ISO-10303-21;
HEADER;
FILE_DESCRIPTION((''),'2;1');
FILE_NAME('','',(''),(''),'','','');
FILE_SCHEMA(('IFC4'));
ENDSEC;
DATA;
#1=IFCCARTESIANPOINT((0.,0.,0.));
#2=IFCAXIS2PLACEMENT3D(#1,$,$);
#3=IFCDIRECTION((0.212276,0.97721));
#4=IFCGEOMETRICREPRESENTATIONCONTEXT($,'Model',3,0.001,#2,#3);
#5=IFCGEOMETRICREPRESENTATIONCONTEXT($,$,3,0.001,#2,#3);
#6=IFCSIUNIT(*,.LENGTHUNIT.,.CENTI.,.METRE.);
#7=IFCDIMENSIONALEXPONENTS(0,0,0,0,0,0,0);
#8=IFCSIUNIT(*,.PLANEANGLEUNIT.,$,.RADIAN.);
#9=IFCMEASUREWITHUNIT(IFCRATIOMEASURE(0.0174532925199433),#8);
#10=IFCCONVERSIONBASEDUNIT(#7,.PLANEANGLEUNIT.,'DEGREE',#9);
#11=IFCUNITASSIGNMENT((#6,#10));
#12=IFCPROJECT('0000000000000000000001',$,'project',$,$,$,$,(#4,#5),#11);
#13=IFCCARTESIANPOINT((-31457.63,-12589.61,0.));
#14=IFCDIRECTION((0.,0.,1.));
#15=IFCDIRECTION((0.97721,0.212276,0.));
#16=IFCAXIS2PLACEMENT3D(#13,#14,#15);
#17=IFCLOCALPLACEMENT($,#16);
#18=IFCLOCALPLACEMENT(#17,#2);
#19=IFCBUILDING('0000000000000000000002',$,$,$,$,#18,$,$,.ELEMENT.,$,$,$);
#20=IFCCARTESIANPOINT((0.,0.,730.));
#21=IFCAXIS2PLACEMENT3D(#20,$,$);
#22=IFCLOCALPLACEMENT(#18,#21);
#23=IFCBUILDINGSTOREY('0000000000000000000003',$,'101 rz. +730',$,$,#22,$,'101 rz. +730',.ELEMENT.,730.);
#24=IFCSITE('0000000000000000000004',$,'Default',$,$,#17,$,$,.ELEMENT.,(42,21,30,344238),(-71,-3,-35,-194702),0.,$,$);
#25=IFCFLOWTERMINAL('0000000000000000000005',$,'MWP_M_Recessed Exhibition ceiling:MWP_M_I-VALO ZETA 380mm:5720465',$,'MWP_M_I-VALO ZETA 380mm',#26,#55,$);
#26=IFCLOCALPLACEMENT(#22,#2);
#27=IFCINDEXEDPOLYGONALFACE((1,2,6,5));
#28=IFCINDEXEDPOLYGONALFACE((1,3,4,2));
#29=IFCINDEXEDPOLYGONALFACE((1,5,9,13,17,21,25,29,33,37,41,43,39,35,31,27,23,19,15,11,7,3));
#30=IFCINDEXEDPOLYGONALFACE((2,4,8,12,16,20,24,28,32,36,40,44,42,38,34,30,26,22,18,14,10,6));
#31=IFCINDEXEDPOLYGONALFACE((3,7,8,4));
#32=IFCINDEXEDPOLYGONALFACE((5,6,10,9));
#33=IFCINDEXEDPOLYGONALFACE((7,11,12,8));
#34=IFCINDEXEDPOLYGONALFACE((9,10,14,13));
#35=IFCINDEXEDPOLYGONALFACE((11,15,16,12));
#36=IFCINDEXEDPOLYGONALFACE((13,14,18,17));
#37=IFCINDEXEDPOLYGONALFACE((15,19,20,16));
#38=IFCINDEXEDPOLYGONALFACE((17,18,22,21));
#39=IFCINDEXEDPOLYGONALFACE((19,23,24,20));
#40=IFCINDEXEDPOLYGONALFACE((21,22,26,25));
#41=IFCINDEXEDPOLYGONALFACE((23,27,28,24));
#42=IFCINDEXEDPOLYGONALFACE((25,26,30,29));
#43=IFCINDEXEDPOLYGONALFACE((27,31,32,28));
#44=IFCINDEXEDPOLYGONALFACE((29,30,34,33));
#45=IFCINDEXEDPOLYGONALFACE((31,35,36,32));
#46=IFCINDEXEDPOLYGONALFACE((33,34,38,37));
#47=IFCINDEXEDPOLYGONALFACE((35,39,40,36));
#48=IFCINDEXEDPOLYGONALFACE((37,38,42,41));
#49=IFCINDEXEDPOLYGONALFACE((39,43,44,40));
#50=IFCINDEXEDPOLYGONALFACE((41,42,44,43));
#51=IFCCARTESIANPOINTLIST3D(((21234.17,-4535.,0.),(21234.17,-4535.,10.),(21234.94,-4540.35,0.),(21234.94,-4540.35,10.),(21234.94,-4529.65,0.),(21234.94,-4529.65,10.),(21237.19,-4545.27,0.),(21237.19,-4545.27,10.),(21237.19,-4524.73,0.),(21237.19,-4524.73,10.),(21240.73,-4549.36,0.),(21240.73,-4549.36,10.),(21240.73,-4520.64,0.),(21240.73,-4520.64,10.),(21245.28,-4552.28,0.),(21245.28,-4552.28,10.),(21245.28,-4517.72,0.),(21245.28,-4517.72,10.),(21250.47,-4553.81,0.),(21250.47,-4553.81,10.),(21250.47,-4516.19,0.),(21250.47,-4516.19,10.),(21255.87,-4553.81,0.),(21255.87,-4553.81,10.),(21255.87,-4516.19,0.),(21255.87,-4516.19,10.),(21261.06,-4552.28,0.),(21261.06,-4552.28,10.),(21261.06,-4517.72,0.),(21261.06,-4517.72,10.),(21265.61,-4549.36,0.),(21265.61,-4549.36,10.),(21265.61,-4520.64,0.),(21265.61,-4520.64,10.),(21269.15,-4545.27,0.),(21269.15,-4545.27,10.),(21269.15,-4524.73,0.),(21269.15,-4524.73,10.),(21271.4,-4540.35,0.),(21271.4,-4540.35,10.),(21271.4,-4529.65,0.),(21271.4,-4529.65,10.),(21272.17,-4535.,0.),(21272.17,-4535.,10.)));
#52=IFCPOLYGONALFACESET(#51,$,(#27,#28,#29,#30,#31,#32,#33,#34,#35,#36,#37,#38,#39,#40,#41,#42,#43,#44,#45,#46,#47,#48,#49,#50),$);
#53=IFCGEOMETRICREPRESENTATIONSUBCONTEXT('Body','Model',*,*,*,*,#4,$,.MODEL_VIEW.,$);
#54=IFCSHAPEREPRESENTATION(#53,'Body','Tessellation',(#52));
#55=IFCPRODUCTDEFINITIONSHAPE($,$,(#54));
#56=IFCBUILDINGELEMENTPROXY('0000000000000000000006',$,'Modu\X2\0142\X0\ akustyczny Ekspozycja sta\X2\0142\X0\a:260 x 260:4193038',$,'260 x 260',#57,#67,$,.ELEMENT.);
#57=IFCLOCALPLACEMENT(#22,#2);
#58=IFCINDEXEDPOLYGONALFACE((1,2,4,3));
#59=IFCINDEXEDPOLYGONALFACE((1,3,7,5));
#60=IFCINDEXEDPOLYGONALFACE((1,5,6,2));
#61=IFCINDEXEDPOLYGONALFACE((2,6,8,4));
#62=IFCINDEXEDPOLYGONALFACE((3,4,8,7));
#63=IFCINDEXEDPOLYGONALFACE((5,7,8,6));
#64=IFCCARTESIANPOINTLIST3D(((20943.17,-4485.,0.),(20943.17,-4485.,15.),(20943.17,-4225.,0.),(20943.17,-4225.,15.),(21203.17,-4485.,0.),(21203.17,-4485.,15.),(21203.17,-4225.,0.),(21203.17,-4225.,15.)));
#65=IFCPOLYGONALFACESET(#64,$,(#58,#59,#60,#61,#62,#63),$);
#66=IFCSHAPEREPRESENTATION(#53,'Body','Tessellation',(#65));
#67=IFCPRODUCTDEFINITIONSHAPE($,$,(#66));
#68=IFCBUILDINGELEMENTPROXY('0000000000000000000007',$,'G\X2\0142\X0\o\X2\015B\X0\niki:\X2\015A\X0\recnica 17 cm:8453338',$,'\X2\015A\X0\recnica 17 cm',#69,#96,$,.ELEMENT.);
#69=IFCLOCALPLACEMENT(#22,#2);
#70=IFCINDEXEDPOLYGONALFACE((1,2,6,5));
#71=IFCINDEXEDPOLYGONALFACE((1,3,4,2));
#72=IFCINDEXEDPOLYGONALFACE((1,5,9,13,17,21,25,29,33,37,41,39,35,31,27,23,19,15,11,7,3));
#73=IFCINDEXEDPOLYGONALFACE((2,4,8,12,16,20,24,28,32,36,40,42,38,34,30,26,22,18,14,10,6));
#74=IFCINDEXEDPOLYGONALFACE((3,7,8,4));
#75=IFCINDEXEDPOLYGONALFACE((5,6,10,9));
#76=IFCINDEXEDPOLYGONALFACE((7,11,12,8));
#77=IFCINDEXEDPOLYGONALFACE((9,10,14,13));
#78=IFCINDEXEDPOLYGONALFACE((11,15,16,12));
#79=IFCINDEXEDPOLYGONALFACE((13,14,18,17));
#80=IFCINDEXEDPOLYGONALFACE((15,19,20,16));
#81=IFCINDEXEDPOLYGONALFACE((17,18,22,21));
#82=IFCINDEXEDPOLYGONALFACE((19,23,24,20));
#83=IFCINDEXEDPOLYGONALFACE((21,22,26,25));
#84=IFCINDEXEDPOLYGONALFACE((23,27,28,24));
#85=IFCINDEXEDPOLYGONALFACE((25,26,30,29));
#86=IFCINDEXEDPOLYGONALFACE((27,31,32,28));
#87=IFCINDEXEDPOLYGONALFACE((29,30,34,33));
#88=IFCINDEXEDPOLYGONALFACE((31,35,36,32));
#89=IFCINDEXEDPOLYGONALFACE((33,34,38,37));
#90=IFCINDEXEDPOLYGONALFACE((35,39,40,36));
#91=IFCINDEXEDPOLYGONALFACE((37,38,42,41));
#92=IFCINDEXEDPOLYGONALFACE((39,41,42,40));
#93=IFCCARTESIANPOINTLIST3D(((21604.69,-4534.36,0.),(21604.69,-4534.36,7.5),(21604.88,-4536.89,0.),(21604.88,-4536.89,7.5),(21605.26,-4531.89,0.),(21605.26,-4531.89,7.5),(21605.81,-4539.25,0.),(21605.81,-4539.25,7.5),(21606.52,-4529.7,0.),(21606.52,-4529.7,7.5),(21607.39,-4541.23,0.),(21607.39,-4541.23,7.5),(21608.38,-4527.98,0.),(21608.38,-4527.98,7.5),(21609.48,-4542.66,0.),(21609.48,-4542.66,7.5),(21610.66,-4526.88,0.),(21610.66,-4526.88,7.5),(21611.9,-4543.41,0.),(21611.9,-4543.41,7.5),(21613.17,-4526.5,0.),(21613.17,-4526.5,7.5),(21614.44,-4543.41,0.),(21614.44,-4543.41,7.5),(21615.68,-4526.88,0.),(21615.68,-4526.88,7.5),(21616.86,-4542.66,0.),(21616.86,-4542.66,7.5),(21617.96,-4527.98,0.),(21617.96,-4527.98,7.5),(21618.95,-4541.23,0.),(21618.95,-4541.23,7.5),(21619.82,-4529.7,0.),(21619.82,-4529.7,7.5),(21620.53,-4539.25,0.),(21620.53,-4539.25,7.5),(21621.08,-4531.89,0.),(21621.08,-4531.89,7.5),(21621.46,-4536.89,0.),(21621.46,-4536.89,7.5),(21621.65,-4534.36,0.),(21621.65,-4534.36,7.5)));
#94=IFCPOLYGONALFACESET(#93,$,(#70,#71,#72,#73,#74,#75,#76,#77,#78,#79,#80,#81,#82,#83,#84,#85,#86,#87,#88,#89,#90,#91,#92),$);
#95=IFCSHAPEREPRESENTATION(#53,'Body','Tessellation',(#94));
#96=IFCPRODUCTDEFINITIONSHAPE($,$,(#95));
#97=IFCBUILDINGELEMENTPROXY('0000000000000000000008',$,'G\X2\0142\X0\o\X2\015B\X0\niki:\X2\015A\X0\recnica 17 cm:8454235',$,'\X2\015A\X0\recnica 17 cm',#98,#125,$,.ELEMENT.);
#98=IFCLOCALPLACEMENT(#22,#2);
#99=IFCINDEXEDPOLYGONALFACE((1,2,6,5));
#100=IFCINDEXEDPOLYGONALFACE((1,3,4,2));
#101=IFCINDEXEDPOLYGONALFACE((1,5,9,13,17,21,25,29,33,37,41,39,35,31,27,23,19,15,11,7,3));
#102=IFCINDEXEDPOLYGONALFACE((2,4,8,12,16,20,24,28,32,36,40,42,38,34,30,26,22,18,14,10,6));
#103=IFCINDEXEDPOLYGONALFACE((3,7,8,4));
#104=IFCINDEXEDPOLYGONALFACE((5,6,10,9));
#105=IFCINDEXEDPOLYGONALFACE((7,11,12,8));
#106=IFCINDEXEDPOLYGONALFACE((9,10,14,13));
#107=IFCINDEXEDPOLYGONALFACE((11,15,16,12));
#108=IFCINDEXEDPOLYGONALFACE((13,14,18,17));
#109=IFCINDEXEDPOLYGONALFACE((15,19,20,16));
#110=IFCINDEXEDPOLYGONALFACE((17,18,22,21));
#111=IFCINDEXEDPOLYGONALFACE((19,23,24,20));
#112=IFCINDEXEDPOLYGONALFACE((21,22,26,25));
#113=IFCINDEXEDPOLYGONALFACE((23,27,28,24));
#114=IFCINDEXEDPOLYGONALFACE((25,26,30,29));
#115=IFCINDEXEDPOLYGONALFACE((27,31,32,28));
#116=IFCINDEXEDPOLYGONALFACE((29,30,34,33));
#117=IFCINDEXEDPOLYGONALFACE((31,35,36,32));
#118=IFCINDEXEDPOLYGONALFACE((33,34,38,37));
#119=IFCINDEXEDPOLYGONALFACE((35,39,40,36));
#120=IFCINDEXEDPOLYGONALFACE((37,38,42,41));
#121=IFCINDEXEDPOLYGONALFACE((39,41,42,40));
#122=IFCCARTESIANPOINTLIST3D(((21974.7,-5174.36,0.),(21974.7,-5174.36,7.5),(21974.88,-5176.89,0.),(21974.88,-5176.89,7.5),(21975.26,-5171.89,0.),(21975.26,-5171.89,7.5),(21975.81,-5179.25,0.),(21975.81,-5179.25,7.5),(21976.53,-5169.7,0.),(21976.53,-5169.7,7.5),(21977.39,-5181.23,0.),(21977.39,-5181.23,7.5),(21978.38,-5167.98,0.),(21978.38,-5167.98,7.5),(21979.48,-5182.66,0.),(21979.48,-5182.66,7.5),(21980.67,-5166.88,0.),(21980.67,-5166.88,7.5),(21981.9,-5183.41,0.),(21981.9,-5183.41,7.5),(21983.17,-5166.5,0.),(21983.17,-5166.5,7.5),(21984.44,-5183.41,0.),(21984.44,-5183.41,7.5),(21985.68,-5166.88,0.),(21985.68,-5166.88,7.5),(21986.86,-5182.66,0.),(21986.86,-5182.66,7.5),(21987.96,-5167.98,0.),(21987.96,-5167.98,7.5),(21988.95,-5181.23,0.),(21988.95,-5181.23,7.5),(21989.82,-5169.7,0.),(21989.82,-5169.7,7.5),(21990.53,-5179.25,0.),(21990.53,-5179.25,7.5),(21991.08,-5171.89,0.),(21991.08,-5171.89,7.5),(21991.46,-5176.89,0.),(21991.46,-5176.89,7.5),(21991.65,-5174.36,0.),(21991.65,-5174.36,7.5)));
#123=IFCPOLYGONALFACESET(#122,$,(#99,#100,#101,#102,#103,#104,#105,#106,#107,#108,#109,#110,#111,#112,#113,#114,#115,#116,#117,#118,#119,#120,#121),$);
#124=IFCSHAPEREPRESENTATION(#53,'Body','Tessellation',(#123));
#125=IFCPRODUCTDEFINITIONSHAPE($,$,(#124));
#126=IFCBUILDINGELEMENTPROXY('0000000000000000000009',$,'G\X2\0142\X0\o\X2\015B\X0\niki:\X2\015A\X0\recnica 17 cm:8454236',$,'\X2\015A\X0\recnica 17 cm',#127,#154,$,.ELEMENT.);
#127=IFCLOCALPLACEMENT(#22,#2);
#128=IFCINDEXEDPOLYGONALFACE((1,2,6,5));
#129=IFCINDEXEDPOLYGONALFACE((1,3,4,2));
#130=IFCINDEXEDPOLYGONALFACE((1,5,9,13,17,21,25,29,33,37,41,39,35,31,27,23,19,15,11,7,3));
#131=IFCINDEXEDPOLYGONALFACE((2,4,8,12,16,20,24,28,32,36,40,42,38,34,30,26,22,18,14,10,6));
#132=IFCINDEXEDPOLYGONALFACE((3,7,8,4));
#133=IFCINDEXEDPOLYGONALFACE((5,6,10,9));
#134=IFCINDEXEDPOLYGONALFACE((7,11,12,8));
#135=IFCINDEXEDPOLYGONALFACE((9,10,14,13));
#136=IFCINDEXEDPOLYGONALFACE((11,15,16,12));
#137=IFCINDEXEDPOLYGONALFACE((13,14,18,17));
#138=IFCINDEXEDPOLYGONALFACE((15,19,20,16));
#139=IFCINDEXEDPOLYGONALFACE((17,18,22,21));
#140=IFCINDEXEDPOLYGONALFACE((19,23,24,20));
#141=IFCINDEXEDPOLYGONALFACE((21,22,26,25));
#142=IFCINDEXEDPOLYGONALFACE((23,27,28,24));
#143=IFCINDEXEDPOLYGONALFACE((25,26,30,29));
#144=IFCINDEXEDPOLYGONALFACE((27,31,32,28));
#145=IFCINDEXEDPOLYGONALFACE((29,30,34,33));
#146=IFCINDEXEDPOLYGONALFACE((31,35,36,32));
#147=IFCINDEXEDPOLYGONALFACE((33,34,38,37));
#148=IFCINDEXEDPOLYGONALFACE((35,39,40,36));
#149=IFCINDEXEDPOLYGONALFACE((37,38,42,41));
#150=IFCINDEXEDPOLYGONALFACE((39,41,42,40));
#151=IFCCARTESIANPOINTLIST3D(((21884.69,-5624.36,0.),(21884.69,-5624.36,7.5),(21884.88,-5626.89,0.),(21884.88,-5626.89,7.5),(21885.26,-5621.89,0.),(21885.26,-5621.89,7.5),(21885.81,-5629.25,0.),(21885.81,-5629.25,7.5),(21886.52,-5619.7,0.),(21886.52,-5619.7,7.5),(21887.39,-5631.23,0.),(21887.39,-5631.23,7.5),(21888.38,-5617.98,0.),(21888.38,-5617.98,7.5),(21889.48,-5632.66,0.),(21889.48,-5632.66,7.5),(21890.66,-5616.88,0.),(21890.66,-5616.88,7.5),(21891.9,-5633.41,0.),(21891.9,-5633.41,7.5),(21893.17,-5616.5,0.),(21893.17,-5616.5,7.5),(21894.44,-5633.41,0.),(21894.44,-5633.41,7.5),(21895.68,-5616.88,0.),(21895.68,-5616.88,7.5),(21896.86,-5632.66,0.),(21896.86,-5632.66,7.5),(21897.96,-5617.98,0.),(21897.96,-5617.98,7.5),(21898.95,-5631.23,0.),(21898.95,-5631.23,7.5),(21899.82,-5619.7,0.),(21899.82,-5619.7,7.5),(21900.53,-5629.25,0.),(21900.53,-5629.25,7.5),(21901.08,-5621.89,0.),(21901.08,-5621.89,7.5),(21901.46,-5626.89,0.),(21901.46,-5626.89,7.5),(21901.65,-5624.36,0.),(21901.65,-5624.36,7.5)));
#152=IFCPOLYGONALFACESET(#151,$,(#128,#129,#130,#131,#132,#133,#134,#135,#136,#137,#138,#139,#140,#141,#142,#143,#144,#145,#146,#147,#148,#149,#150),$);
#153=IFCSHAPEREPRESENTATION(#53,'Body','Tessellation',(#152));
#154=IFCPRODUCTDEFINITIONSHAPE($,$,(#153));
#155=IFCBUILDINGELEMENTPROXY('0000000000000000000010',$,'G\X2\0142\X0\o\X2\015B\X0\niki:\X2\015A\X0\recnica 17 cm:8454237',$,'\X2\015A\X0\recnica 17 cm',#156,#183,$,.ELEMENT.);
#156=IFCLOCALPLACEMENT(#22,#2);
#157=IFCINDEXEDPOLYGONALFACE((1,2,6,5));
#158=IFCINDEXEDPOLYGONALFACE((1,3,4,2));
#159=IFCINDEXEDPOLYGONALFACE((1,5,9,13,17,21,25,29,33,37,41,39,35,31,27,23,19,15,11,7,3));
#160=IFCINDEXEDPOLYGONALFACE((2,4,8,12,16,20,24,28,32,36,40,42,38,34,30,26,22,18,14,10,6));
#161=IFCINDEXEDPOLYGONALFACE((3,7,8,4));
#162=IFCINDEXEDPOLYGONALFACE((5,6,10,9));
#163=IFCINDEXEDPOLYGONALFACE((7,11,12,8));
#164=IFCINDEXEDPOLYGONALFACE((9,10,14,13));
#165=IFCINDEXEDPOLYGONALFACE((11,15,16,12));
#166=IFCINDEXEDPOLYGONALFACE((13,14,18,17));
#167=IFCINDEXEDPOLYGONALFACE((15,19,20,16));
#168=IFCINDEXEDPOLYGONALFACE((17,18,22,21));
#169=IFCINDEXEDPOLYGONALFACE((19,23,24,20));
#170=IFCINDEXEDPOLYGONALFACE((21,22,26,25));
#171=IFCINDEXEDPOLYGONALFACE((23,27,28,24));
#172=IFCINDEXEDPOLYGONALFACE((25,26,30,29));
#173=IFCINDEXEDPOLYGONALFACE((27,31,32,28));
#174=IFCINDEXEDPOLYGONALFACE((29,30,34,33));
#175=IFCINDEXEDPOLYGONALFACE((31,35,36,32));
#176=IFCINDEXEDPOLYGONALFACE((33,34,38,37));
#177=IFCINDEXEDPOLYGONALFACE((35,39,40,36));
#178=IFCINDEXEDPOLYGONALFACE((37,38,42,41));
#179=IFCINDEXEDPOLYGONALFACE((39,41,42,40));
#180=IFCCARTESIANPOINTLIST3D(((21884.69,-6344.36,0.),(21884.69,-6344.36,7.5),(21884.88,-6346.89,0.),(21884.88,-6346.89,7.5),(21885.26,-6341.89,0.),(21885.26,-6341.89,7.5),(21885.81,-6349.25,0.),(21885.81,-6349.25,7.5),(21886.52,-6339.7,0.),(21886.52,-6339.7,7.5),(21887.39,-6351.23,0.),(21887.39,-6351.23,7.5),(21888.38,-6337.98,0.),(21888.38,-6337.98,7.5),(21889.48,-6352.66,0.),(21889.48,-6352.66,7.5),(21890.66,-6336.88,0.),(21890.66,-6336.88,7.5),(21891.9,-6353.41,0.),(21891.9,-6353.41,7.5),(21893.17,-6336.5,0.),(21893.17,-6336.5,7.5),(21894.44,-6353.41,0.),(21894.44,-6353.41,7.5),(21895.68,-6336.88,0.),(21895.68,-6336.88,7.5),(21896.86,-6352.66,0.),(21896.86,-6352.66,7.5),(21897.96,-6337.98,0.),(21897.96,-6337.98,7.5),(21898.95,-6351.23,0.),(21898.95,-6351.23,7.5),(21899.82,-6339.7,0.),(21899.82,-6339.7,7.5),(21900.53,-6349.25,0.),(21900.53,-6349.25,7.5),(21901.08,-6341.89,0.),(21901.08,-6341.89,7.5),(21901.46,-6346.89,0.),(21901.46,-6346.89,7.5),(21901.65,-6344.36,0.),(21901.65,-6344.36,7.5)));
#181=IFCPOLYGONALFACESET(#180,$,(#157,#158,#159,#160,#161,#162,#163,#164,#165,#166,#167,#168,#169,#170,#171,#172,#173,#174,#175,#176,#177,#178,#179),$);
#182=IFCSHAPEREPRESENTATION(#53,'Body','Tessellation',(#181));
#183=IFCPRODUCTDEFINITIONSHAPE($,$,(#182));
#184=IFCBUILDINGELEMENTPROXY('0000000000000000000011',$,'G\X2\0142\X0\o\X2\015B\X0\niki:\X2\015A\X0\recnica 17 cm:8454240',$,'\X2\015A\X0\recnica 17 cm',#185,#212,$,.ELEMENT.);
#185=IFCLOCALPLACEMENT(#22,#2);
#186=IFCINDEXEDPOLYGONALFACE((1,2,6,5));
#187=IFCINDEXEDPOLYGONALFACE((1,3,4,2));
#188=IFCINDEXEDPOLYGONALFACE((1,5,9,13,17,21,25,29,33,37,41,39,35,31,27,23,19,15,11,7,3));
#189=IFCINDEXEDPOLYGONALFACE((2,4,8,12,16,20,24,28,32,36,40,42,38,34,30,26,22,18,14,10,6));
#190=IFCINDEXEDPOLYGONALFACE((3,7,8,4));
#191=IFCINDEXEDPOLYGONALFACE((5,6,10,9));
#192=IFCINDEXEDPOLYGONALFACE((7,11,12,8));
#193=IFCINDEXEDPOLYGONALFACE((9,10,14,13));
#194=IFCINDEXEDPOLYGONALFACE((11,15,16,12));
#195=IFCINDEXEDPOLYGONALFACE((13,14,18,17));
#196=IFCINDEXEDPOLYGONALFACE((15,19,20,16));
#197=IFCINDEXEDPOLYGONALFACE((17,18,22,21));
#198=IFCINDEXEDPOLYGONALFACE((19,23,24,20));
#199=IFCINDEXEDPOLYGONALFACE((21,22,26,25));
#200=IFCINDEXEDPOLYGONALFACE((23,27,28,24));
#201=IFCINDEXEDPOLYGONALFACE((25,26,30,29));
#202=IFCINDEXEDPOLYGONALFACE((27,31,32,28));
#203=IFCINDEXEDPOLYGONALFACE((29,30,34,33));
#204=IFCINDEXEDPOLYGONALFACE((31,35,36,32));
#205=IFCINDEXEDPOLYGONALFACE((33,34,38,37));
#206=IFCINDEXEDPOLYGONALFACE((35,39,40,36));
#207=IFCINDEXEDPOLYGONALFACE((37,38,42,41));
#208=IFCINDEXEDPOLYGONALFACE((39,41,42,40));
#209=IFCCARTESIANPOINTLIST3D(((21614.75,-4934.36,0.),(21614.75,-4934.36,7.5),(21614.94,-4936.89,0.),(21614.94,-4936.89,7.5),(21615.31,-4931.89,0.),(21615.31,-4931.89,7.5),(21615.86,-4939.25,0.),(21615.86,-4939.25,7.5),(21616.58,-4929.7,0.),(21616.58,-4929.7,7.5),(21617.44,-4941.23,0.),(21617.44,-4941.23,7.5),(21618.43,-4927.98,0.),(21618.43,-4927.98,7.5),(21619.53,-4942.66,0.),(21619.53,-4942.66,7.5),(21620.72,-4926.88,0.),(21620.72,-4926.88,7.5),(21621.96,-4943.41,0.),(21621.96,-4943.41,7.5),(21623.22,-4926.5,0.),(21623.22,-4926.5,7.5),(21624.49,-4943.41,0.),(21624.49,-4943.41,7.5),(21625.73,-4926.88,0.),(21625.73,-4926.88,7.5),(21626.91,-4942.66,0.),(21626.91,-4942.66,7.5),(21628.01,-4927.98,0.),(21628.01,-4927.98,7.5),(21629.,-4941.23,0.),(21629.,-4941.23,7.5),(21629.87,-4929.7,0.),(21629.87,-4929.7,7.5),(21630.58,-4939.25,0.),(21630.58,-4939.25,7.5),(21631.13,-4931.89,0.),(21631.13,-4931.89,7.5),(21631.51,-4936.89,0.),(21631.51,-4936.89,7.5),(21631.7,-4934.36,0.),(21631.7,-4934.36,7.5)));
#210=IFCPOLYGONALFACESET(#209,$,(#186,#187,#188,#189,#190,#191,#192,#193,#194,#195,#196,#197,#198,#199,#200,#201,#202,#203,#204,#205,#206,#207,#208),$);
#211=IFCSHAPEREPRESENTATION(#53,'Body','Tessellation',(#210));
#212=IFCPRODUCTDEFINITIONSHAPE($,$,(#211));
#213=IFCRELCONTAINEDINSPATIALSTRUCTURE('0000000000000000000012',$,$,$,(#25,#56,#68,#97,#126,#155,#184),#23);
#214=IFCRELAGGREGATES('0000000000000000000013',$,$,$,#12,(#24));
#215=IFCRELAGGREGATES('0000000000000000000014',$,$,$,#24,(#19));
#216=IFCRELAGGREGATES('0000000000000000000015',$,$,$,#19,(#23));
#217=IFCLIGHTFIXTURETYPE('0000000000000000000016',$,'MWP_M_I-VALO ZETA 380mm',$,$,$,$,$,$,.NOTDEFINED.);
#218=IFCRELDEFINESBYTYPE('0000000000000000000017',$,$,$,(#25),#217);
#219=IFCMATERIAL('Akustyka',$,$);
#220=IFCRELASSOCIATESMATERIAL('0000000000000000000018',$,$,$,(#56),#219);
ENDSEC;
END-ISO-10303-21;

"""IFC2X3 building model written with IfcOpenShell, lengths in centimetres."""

from ifc_helpers import new_model, entity, si_unit, converted_unit, direction, frame, frame_2d, origin, origin_2d_with_axis, place, context, subcontext, project, spatial, rectangle, circle, extrude, source, transform, mapped, material, type_object, type_shapes, element, save


model = new_model("IFC2X3")

# Units and contexts
model_context = context("Model", 3, precision=0.001, world=origin(), true_north=direction((0.212276, 0.97721)))
context_of_model = context(None, 3, precision=0.001, world=origin(), true_north=direction((0.212276, 0.97721)))
body_context = subcontext(model_context, "Body", "Model", "MODEL_VIEW")
ifc_project = project(units=[si_unit("LENGTHUNIT", "METRE", prefix="CENTI"), converted_unit("PLANEANGLEUNIT", "DEGREE", entity("IfcRatioMeasure", 0.0174532925199433), si_unit("PLANEANGLEUNIT", "RADIAN"), dimensions=[0, 0, 0, 0, 0, 0, 0])], contexts=[model_context, context_of_model])

# Site, building, storey
site_placement = place(None, frame((-31457.63, -12589.61, 0.0), z_axis=(0.0, 0.0, 1.0), x_axis=(0.97721, 0.212276, 0.0)))
site = spatial("IfcSite", under=ifc_project, at=site_placement, Name="Default", CompositionType="ELEMENT", RefLatitude=(42, 21, 30, 344238), RefLongitude=(-71, -3, -35, -194702), RefElevation=0.0)
building_placement = place(site_placement, origin())
building = spatial("IfcBuilding", under=site, at=building_placement, CompositionType="ELEMENT")
storey_placement = place(building_placement, frame((0.0, 0.0, 730.0)))
storey = spatial("IfcBuildingStorey", under=building, at=storey_placement, Name="101 rz. +730", LongName="101 rz. +730", CompositionType="ELEMENT", Elevation=730.0)

# Flow terminal
light_fixture_type = type_object("IfcLightFixtureType", Name="MWP_M_I-VALO ZETA 380mm", PredefinedType="NOTDEFINED")
shared_shape_1 = source(origin(), body_context, "Body", "SweptSolid", [
    extrude(circle(Radius=19.0, at=frame_2d((0.0, 0.0), x_axis=(1.0, 0.0))), frame((0.0, 0.0, -10.0)), (0.0, 0.0, 1.0), 10.0),
])
type_shapes(light_fixture_type, [shared_shape_1])
flow_terminal_placement = place(storey_placement, frame((21253.17, -4535.0, 0.0), z_axis=(0.0, 0.0, -1.0), x_axis=(1.0, 0.0, 0.0)))
element("IfcFlowTerminal", 1, at=flow_terminal_placement, inside=storey, type_object=light_fixture_type, Name="MWP_M_Recessed Exhibition ceiling:MWP_M_I-VALO ZETA 380mm:5720465", ObjectType="MWP_M_I-VALO ZETA 380mm", context=body_context, shape_type="MappedRepresentation", body=[
    mapped(shared_shape_1, transform((0.0, 0.0, 0.0), scale=1.0)),
])

# Building element proxies
ifc_material_1 = material(Name="Akustyka")
shared_shape_2 = source(origin(), body_context, "Body", "SweptSolid", [
    extrude(rectangle(XDim=260.0, YDim=260.0, at=origin_2d_with_axis()), frame((0.0, 0.0, -15.0), z_axis=(0.0, 0.0, 1.0), x_axis=(-1.0, 0.0, 0.0)), (0.0, 0.0, 1.0), 15.0),
])
proxy_placement = place(storey_placement, frame((21073.17, -4355.0, 0.0), z_axis=(0.0, 0.0, -1.0), x_axis=(1.0, 0.0, 0.0)))
element("IfcBuildingElementProxy", 2, at=proxy_placement, inside=storey, material=ifc_material_1, Name="Moduł akustyczny Ekspozycja stała:260 x 260:4193038", ObjectType="260 x 260", CompositionType="ELEMENT", context=body_context, shape_type="MappedRepresentation", body=[
    mapped(shared_shape_2, transform((0.0, 0.0, 0.0), scale=1.0)),
])
shared_shape_3 = source(origin(), body_context, "Body", "SweptSolid", [
    extrude(circle(Radius=8.5, at=frame_2d((0.0, 0.0), x_axis=(1.0, 0.0))), frame((0.0, 0.0, 0.0), z_axis=(0.0, 0.0, 1.0), x_axis=(0.0, 1.0, 0.0)), (0.0, 0.0, 1.0), 7.5),
])
for number, where, name in (
    (3, (21613.17, -4535.0, 0.0), "Głośniki:Śrecnica 17 cm:8453338"),
    (4, (21983.17, -5175.0, 0.0), "Głośniki:Śrecnica 17 cm:8454235"),
    (5, (21893.17, -5625.0, 0.0), "Głośniki:Śrecnica 17 cm:8454236"),
    (6, (21893.17, -6345.0, 0.0), "Głośniki:Śrecnica 17 cm:8454237"),
    (7, (21623.22, -4935.0, 0.0), "Głośniki:Śrecnica 17 cm:8454240"),
):
    element("IfcBuildingElementProxy", number, at=place(storey_placement, frame(where)), inside=storey, Name=name, ObjectType="Śrecnica 17 cm", CompositionType="ELEMENT", context=body_context, shape_type="MappedRepresentation", body=[
        mapped(shared_shape_3, transform((0.0, 0.0, 0.0), scale=1.0)),
    ])

save(model, "model.ifc")
